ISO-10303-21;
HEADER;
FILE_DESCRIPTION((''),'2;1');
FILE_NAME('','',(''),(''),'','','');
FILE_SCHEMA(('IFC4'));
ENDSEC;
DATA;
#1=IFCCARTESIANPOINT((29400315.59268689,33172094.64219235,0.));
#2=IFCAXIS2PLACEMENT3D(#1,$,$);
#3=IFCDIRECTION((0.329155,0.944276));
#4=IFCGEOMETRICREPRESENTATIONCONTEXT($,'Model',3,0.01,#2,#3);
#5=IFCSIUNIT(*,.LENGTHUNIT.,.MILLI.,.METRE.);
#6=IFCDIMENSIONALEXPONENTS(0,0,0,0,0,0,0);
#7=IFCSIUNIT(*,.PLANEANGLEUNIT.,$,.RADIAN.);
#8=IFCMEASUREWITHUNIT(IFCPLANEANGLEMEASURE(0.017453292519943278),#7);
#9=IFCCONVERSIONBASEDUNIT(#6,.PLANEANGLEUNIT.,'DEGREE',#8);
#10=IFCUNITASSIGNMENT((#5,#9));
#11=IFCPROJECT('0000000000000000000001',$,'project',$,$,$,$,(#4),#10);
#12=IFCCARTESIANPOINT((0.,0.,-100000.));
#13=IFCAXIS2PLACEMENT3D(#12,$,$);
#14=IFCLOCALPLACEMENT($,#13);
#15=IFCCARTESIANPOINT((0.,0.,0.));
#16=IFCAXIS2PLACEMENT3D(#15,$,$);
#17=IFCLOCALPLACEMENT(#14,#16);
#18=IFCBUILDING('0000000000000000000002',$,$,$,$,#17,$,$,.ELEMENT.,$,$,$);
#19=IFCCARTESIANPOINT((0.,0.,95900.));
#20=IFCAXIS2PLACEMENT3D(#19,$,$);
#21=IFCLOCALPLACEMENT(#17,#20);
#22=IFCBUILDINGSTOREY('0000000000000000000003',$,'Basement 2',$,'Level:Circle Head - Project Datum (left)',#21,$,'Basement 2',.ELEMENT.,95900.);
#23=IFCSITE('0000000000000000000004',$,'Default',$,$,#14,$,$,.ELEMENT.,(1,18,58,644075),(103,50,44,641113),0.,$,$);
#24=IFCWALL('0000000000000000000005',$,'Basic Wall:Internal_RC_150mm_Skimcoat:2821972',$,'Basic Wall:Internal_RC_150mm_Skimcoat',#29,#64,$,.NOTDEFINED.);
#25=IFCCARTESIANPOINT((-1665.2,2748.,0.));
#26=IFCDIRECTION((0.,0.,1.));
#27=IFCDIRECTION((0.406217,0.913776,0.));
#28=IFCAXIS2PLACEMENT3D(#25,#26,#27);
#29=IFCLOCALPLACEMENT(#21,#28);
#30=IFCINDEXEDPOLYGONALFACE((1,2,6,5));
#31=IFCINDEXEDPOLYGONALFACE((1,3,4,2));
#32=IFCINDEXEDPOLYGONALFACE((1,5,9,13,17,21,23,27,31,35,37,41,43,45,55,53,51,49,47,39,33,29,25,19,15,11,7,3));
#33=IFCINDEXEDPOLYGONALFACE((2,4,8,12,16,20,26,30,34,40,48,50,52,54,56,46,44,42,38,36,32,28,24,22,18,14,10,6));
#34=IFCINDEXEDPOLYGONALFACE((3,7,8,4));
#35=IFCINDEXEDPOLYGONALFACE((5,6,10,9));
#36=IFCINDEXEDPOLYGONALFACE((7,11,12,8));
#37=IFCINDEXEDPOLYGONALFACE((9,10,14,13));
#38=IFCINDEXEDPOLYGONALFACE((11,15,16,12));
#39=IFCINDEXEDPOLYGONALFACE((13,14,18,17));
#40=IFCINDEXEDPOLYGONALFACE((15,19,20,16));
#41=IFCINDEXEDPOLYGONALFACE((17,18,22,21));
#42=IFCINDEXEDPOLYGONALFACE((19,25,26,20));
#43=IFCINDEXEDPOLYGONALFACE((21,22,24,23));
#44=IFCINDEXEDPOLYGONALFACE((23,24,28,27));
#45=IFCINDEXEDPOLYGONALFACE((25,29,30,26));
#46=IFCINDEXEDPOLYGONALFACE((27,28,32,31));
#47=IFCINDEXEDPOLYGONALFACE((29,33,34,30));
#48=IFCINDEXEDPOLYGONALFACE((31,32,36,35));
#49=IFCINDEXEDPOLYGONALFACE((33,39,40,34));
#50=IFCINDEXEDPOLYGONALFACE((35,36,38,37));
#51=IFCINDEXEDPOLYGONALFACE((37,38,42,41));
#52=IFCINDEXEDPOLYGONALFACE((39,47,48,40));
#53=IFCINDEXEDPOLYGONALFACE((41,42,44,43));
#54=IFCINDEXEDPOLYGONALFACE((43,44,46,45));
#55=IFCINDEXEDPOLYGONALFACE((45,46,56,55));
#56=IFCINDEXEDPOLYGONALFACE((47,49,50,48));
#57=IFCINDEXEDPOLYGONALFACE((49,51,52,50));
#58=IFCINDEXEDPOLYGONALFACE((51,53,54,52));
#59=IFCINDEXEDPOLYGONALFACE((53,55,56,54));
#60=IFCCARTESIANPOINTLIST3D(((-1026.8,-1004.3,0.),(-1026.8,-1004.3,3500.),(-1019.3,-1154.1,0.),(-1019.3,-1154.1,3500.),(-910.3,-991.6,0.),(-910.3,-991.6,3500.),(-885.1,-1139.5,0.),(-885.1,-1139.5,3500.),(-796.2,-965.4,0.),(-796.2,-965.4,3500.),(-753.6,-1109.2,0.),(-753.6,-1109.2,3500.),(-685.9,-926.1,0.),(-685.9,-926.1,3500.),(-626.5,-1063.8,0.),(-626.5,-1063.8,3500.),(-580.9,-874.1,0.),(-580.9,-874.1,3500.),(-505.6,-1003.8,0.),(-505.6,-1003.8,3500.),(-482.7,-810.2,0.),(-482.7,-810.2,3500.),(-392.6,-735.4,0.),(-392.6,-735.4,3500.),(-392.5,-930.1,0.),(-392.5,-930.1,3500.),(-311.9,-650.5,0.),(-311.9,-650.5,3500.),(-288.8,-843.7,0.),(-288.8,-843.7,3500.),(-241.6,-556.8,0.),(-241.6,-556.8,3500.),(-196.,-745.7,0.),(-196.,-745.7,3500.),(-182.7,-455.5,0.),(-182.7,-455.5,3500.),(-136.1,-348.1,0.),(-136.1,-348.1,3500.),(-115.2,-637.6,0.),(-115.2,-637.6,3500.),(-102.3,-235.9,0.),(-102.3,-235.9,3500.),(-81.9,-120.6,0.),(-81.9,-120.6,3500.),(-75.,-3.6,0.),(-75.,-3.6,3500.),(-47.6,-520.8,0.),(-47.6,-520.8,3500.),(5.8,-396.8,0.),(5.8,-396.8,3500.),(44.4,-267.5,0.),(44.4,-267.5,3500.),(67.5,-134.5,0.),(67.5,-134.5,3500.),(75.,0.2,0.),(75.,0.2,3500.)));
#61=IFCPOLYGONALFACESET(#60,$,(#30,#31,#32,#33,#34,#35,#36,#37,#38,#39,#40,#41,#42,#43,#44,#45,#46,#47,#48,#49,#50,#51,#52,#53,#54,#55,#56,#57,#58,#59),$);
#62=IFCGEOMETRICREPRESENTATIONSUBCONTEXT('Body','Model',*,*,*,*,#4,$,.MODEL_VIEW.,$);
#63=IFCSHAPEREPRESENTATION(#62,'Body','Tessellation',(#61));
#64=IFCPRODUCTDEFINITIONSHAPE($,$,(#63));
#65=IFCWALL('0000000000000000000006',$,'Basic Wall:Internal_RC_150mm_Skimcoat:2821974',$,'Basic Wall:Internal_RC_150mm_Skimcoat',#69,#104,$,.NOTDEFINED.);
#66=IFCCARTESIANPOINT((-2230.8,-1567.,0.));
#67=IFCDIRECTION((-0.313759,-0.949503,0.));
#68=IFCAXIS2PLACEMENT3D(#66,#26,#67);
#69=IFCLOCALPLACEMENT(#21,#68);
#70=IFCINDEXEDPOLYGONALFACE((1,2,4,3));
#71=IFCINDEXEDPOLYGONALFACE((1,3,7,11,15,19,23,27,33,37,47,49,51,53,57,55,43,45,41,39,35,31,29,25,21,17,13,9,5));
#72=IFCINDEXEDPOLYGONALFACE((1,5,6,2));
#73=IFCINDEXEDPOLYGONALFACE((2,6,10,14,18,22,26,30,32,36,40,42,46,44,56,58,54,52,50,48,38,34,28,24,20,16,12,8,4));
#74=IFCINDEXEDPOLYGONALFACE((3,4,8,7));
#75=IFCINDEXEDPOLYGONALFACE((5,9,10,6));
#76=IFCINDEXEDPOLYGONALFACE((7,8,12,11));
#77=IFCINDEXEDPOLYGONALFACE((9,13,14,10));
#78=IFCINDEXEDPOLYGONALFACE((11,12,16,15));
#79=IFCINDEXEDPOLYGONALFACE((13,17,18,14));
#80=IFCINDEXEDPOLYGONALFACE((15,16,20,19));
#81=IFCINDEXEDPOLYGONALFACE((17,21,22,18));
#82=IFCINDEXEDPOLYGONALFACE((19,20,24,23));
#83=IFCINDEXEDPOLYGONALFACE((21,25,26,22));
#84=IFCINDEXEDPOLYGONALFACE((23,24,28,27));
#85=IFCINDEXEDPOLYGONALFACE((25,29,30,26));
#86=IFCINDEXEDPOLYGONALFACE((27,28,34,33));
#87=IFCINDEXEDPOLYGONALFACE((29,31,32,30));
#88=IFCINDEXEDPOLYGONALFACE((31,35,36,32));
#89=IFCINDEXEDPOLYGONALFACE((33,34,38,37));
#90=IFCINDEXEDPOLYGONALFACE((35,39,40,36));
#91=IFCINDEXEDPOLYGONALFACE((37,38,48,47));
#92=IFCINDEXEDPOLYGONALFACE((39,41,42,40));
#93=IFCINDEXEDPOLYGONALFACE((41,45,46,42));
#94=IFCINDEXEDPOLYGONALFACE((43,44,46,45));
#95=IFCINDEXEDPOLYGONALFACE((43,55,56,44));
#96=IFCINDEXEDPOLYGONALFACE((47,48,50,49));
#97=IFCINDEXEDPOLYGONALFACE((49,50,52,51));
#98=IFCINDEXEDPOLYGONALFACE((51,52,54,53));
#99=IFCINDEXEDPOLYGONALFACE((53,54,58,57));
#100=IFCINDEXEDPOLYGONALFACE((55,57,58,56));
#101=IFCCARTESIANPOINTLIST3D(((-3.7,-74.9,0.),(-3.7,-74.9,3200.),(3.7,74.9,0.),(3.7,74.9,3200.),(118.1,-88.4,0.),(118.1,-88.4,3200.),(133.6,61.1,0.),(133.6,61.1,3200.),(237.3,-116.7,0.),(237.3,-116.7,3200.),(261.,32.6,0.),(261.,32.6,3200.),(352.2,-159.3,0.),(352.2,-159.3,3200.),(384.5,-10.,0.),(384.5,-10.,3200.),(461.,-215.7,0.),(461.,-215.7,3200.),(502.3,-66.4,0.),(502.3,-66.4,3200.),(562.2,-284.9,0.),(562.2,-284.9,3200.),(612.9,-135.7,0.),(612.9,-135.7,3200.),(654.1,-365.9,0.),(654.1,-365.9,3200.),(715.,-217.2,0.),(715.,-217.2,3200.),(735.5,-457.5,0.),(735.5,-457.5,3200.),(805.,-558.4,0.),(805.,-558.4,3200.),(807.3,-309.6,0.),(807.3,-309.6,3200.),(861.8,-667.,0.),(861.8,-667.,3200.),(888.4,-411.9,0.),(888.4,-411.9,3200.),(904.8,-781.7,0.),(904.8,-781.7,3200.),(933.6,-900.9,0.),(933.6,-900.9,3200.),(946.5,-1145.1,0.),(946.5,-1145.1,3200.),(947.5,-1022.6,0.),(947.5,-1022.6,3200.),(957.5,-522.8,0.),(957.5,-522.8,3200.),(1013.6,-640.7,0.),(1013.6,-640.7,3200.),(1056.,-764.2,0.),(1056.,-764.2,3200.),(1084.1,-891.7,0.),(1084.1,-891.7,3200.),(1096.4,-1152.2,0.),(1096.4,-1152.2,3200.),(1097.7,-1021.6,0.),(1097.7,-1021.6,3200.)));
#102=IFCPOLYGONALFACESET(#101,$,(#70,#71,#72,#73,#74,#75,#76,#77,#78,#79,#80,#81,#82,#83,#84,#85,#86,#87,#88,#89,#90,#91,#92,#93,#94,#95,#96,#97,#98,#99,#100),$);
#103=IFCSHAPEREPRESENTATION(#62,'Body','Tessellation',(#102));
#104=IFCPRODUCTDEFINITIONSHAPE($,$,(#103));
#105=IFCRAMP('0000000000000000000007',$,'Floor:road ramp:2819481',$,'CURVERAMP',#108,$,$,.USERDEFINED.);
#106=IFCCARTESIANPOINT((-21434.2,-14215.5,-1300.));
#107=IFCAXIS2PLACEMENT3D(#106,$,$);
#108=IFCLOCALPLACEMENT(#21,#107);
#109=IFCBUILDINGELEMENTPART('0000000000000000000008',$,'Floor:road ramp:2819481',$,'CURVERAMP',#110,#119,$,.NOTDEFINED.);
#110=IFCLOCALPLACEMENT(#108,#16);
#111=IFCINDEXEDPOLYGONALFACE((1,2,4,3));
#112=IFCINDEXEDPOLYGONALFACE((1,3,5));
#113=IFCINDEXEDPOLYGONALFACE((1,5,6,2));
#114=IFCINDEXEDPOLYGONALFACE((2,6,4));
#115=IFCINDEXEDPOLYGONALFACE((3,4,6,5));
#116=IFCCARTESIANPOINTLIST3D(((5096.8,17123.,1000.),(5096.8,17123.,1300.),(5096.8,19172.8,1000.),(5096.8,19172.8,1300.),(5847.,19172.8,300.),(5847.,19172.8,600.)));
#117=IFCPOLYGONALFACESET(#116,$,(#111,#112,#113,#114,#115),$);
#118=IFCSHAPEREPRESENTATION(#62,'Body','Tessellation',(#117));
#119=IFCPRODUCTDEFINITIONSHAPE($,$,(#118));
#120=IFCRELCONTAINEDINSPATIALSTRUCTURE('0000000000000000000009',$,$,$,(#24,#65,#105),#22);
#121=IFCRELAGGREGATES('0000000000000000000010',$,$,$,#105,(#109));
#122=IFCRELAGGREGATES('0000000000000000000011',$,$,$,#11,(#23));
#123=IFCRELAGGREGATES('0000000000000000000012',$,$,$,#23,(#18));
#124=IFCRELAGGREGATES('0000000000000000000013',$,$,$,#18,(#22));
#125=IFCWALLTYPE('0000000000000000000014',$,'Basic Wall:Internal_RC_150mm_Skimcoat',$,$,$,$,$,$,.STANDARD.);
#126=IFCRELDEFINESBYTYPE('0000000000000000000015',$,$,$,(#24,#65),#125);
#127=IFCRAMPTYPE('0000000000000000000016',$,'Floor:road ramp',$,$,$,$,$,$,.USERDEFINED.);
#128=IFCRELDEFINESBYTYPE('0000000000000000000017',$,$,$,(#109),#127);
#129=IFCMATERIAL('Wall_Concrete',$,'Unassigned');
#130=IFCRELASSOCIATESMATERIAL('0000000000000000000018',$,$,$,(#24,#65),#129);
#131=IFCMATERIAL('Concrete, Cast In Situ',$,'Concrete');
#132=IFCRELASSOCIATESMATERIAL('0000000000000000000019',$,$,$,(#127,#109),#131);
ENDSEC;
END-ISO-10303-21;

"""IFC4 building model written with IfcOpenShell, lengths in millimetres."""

from ifc_helpers import new_model, entity, si_unit, converted_unit, direction, frame, origin, place, context, subcontext, project, spatial, line, arc, indexed_curve, outline, extrude, material, type_object, element, aggregate, save


model = new_model("IFC4")

# Units and contexts
model_context = context("Model", 3, precision=0.01, world=frame((29400315.59268689, 33172094.64219235, 0.0)), true_north=direction((0.329155, 0.944276)))
body_context = subcontext(model_context, "Body", "Model", "MODEL_VIEW")
ifc_project = project(units=[si_unit("LENGTHUNIT", "METRE", prefix="MILLI"), converted_unit("PLANEANGLEUNIT", "DEGREE", entity("IfcPlaneAngleMeasure", 0.017453292519943278), si_unit("PLANEANGLEUNIT", "RADIAN"), dimensions=[0, 0, 0, 0, 0, 0, 0])], contexts=[model_context])

# Site, building, storey
site_placement = place(None, frame((0.0, 0.0, -100000.0)))
site = spatial("IfcSite", under=ifc_project, at=site_placement, Name="Default", CompositionType="ELEMENT", RefLatitude=(1, 18, 58, 644075), RefLongitude=(103, 50, 44, 641113), RefElevation=0.0)
building_placement = place(site_placement, origin())
building = spatial("IfcBuilding", under=site, at=building_placement, CompositionType="ELEMENT")
storey_placement = place(building_placement, frame((0.0, 0.0, 95900.0)))
storey = spatial("IfcBuildingStorey", under=building, at=storey_placement, Name="Basement 2", ObjectType="Level:Circle Head - Project Datum (left)", LongName="Basement 2", CompositionType="ELEMENT", Elevation=95900.0)

# Shared definitions
ifc_material_1 = material(Name="Concrete, Cast In Situ", Category="Concrete")

# Walls
ifc_material_2 = material(Name="Wall_Concrete", Category="Unassigned")
wall_type_1 = type_object("IfcWallType", Name="Basic Wall:Internal_RC_150mm_Skimcoat", PredefinedType="STANDARD")
wall_1_placement = place(storey_placement, frame((-1665.2, 2748.0, 0.0), z_axis=(0.0, 0.0, 1.0), x_axis=(0.406217, 0.913776, 0.0)))
element("IfcWall", 1, at=wall_1_placement, inside=storey, type_object=wall_type_1, material=ifc_material_2, Name="Basic Wall:Internal_RC_150mm_Skimcoat:2821972", ObjectType="Basic Wall:Internal_RC_150mm_Skimcoat", PredefinedType="NOTDEFINED", context=body_context, shape_type="SweptSolid", body=[
    extrude(outline(indexed_curve([(-1019.3, -1154.1), (-241.0, -796.1), (75.0, 0.2), (-75.0, -3.6), (-351.0, -694.1), (-1026.8, -1004.3)], segments=[arc(1, 2, 3), line(3, 4), arc(4, 5, 6), line(6, 1)], self_intersect=False)), origin(), (0.0, 0.0, 1.0), 3500.0),
])
wall_2_placement = place(storey_placement, frame((-2230.8, -1567.0, 0.0), z_axis=(0.0, 0.0, 1.0), x_axis=(-0.313759, -0.949503, 0.0)))
element("IfcWall", 2, at=wall_2_placement, inside=storey, type_object=wall_type_1, material=ifc_material_2, Name="Basic Wall:Internal_RC_150mm_Skimcoat:2821974", ObjectType="Basic Wall:Internal_RC_150mm_Skimcoat", PredefinedType="NOTDEFINED", context=body_context, shape_type="SweptSolid", body=[
    extrude(outline(indexed_curve([(1096.4, -1152.2), (807.3, -309.6), (3.7, 74.9), (-3.7, -74.9), (696.2, -410.4), (946.5, -1145.1)], segments=[arc(1, 2, 3), line(3, 4), arc(4, 5, 6), line(6, 1)], self_intersect=False)), origin(), (0.0, 0.0, 1.0), 3200.0),
])

# Ramp, building element part
ramp_type = type_object("IfcRampType", Name="Floor:road ramp", PredefinedType="USERDEFINED", material=ifc_material_1)
ramp_1_placement = place(storey_placement, frame((-21434.2, -14215.5, -1300.0)))
ramp_1 = element("IfcRamp", 3, at=ramp_1_placement, inside=storey, Name="Floor:road ramp:2819481", ObjectType="CURVERAMP", PredefinedType="USERDEFINED")
building_element_part_1_placement = place(ramp_1_placement, origin())
building_element_part_1 = element("IfcBuildingElementPart", 4, at=building_element_part_1_placement, type_object=ramp_type, material=ifc_material_1, Name="Floor:road ramp:2819481", ObjectType="CURVERAMP", PredefinedType="NOTDEFINED", context=body_context, shape_type="SweptSolid", body=[
    extrude(outline(indexed_curve([(513.0, 1024.9), (-513.0, 1024.9), (-513.0, -1024.9), (513.0, 1024.9)], self_intersect=False)), frame((5471.9, 18147.9, 950.0), z_axis=(0.68221, 0.0, 0.731157), x_axis=(0.731157, 0.0, -0.68221)), (0.68221, 0.0, -0.731157), 300.0),
])
aggregate(ramp_1, [building_element_part_1])

save(model, "model.ifc")
